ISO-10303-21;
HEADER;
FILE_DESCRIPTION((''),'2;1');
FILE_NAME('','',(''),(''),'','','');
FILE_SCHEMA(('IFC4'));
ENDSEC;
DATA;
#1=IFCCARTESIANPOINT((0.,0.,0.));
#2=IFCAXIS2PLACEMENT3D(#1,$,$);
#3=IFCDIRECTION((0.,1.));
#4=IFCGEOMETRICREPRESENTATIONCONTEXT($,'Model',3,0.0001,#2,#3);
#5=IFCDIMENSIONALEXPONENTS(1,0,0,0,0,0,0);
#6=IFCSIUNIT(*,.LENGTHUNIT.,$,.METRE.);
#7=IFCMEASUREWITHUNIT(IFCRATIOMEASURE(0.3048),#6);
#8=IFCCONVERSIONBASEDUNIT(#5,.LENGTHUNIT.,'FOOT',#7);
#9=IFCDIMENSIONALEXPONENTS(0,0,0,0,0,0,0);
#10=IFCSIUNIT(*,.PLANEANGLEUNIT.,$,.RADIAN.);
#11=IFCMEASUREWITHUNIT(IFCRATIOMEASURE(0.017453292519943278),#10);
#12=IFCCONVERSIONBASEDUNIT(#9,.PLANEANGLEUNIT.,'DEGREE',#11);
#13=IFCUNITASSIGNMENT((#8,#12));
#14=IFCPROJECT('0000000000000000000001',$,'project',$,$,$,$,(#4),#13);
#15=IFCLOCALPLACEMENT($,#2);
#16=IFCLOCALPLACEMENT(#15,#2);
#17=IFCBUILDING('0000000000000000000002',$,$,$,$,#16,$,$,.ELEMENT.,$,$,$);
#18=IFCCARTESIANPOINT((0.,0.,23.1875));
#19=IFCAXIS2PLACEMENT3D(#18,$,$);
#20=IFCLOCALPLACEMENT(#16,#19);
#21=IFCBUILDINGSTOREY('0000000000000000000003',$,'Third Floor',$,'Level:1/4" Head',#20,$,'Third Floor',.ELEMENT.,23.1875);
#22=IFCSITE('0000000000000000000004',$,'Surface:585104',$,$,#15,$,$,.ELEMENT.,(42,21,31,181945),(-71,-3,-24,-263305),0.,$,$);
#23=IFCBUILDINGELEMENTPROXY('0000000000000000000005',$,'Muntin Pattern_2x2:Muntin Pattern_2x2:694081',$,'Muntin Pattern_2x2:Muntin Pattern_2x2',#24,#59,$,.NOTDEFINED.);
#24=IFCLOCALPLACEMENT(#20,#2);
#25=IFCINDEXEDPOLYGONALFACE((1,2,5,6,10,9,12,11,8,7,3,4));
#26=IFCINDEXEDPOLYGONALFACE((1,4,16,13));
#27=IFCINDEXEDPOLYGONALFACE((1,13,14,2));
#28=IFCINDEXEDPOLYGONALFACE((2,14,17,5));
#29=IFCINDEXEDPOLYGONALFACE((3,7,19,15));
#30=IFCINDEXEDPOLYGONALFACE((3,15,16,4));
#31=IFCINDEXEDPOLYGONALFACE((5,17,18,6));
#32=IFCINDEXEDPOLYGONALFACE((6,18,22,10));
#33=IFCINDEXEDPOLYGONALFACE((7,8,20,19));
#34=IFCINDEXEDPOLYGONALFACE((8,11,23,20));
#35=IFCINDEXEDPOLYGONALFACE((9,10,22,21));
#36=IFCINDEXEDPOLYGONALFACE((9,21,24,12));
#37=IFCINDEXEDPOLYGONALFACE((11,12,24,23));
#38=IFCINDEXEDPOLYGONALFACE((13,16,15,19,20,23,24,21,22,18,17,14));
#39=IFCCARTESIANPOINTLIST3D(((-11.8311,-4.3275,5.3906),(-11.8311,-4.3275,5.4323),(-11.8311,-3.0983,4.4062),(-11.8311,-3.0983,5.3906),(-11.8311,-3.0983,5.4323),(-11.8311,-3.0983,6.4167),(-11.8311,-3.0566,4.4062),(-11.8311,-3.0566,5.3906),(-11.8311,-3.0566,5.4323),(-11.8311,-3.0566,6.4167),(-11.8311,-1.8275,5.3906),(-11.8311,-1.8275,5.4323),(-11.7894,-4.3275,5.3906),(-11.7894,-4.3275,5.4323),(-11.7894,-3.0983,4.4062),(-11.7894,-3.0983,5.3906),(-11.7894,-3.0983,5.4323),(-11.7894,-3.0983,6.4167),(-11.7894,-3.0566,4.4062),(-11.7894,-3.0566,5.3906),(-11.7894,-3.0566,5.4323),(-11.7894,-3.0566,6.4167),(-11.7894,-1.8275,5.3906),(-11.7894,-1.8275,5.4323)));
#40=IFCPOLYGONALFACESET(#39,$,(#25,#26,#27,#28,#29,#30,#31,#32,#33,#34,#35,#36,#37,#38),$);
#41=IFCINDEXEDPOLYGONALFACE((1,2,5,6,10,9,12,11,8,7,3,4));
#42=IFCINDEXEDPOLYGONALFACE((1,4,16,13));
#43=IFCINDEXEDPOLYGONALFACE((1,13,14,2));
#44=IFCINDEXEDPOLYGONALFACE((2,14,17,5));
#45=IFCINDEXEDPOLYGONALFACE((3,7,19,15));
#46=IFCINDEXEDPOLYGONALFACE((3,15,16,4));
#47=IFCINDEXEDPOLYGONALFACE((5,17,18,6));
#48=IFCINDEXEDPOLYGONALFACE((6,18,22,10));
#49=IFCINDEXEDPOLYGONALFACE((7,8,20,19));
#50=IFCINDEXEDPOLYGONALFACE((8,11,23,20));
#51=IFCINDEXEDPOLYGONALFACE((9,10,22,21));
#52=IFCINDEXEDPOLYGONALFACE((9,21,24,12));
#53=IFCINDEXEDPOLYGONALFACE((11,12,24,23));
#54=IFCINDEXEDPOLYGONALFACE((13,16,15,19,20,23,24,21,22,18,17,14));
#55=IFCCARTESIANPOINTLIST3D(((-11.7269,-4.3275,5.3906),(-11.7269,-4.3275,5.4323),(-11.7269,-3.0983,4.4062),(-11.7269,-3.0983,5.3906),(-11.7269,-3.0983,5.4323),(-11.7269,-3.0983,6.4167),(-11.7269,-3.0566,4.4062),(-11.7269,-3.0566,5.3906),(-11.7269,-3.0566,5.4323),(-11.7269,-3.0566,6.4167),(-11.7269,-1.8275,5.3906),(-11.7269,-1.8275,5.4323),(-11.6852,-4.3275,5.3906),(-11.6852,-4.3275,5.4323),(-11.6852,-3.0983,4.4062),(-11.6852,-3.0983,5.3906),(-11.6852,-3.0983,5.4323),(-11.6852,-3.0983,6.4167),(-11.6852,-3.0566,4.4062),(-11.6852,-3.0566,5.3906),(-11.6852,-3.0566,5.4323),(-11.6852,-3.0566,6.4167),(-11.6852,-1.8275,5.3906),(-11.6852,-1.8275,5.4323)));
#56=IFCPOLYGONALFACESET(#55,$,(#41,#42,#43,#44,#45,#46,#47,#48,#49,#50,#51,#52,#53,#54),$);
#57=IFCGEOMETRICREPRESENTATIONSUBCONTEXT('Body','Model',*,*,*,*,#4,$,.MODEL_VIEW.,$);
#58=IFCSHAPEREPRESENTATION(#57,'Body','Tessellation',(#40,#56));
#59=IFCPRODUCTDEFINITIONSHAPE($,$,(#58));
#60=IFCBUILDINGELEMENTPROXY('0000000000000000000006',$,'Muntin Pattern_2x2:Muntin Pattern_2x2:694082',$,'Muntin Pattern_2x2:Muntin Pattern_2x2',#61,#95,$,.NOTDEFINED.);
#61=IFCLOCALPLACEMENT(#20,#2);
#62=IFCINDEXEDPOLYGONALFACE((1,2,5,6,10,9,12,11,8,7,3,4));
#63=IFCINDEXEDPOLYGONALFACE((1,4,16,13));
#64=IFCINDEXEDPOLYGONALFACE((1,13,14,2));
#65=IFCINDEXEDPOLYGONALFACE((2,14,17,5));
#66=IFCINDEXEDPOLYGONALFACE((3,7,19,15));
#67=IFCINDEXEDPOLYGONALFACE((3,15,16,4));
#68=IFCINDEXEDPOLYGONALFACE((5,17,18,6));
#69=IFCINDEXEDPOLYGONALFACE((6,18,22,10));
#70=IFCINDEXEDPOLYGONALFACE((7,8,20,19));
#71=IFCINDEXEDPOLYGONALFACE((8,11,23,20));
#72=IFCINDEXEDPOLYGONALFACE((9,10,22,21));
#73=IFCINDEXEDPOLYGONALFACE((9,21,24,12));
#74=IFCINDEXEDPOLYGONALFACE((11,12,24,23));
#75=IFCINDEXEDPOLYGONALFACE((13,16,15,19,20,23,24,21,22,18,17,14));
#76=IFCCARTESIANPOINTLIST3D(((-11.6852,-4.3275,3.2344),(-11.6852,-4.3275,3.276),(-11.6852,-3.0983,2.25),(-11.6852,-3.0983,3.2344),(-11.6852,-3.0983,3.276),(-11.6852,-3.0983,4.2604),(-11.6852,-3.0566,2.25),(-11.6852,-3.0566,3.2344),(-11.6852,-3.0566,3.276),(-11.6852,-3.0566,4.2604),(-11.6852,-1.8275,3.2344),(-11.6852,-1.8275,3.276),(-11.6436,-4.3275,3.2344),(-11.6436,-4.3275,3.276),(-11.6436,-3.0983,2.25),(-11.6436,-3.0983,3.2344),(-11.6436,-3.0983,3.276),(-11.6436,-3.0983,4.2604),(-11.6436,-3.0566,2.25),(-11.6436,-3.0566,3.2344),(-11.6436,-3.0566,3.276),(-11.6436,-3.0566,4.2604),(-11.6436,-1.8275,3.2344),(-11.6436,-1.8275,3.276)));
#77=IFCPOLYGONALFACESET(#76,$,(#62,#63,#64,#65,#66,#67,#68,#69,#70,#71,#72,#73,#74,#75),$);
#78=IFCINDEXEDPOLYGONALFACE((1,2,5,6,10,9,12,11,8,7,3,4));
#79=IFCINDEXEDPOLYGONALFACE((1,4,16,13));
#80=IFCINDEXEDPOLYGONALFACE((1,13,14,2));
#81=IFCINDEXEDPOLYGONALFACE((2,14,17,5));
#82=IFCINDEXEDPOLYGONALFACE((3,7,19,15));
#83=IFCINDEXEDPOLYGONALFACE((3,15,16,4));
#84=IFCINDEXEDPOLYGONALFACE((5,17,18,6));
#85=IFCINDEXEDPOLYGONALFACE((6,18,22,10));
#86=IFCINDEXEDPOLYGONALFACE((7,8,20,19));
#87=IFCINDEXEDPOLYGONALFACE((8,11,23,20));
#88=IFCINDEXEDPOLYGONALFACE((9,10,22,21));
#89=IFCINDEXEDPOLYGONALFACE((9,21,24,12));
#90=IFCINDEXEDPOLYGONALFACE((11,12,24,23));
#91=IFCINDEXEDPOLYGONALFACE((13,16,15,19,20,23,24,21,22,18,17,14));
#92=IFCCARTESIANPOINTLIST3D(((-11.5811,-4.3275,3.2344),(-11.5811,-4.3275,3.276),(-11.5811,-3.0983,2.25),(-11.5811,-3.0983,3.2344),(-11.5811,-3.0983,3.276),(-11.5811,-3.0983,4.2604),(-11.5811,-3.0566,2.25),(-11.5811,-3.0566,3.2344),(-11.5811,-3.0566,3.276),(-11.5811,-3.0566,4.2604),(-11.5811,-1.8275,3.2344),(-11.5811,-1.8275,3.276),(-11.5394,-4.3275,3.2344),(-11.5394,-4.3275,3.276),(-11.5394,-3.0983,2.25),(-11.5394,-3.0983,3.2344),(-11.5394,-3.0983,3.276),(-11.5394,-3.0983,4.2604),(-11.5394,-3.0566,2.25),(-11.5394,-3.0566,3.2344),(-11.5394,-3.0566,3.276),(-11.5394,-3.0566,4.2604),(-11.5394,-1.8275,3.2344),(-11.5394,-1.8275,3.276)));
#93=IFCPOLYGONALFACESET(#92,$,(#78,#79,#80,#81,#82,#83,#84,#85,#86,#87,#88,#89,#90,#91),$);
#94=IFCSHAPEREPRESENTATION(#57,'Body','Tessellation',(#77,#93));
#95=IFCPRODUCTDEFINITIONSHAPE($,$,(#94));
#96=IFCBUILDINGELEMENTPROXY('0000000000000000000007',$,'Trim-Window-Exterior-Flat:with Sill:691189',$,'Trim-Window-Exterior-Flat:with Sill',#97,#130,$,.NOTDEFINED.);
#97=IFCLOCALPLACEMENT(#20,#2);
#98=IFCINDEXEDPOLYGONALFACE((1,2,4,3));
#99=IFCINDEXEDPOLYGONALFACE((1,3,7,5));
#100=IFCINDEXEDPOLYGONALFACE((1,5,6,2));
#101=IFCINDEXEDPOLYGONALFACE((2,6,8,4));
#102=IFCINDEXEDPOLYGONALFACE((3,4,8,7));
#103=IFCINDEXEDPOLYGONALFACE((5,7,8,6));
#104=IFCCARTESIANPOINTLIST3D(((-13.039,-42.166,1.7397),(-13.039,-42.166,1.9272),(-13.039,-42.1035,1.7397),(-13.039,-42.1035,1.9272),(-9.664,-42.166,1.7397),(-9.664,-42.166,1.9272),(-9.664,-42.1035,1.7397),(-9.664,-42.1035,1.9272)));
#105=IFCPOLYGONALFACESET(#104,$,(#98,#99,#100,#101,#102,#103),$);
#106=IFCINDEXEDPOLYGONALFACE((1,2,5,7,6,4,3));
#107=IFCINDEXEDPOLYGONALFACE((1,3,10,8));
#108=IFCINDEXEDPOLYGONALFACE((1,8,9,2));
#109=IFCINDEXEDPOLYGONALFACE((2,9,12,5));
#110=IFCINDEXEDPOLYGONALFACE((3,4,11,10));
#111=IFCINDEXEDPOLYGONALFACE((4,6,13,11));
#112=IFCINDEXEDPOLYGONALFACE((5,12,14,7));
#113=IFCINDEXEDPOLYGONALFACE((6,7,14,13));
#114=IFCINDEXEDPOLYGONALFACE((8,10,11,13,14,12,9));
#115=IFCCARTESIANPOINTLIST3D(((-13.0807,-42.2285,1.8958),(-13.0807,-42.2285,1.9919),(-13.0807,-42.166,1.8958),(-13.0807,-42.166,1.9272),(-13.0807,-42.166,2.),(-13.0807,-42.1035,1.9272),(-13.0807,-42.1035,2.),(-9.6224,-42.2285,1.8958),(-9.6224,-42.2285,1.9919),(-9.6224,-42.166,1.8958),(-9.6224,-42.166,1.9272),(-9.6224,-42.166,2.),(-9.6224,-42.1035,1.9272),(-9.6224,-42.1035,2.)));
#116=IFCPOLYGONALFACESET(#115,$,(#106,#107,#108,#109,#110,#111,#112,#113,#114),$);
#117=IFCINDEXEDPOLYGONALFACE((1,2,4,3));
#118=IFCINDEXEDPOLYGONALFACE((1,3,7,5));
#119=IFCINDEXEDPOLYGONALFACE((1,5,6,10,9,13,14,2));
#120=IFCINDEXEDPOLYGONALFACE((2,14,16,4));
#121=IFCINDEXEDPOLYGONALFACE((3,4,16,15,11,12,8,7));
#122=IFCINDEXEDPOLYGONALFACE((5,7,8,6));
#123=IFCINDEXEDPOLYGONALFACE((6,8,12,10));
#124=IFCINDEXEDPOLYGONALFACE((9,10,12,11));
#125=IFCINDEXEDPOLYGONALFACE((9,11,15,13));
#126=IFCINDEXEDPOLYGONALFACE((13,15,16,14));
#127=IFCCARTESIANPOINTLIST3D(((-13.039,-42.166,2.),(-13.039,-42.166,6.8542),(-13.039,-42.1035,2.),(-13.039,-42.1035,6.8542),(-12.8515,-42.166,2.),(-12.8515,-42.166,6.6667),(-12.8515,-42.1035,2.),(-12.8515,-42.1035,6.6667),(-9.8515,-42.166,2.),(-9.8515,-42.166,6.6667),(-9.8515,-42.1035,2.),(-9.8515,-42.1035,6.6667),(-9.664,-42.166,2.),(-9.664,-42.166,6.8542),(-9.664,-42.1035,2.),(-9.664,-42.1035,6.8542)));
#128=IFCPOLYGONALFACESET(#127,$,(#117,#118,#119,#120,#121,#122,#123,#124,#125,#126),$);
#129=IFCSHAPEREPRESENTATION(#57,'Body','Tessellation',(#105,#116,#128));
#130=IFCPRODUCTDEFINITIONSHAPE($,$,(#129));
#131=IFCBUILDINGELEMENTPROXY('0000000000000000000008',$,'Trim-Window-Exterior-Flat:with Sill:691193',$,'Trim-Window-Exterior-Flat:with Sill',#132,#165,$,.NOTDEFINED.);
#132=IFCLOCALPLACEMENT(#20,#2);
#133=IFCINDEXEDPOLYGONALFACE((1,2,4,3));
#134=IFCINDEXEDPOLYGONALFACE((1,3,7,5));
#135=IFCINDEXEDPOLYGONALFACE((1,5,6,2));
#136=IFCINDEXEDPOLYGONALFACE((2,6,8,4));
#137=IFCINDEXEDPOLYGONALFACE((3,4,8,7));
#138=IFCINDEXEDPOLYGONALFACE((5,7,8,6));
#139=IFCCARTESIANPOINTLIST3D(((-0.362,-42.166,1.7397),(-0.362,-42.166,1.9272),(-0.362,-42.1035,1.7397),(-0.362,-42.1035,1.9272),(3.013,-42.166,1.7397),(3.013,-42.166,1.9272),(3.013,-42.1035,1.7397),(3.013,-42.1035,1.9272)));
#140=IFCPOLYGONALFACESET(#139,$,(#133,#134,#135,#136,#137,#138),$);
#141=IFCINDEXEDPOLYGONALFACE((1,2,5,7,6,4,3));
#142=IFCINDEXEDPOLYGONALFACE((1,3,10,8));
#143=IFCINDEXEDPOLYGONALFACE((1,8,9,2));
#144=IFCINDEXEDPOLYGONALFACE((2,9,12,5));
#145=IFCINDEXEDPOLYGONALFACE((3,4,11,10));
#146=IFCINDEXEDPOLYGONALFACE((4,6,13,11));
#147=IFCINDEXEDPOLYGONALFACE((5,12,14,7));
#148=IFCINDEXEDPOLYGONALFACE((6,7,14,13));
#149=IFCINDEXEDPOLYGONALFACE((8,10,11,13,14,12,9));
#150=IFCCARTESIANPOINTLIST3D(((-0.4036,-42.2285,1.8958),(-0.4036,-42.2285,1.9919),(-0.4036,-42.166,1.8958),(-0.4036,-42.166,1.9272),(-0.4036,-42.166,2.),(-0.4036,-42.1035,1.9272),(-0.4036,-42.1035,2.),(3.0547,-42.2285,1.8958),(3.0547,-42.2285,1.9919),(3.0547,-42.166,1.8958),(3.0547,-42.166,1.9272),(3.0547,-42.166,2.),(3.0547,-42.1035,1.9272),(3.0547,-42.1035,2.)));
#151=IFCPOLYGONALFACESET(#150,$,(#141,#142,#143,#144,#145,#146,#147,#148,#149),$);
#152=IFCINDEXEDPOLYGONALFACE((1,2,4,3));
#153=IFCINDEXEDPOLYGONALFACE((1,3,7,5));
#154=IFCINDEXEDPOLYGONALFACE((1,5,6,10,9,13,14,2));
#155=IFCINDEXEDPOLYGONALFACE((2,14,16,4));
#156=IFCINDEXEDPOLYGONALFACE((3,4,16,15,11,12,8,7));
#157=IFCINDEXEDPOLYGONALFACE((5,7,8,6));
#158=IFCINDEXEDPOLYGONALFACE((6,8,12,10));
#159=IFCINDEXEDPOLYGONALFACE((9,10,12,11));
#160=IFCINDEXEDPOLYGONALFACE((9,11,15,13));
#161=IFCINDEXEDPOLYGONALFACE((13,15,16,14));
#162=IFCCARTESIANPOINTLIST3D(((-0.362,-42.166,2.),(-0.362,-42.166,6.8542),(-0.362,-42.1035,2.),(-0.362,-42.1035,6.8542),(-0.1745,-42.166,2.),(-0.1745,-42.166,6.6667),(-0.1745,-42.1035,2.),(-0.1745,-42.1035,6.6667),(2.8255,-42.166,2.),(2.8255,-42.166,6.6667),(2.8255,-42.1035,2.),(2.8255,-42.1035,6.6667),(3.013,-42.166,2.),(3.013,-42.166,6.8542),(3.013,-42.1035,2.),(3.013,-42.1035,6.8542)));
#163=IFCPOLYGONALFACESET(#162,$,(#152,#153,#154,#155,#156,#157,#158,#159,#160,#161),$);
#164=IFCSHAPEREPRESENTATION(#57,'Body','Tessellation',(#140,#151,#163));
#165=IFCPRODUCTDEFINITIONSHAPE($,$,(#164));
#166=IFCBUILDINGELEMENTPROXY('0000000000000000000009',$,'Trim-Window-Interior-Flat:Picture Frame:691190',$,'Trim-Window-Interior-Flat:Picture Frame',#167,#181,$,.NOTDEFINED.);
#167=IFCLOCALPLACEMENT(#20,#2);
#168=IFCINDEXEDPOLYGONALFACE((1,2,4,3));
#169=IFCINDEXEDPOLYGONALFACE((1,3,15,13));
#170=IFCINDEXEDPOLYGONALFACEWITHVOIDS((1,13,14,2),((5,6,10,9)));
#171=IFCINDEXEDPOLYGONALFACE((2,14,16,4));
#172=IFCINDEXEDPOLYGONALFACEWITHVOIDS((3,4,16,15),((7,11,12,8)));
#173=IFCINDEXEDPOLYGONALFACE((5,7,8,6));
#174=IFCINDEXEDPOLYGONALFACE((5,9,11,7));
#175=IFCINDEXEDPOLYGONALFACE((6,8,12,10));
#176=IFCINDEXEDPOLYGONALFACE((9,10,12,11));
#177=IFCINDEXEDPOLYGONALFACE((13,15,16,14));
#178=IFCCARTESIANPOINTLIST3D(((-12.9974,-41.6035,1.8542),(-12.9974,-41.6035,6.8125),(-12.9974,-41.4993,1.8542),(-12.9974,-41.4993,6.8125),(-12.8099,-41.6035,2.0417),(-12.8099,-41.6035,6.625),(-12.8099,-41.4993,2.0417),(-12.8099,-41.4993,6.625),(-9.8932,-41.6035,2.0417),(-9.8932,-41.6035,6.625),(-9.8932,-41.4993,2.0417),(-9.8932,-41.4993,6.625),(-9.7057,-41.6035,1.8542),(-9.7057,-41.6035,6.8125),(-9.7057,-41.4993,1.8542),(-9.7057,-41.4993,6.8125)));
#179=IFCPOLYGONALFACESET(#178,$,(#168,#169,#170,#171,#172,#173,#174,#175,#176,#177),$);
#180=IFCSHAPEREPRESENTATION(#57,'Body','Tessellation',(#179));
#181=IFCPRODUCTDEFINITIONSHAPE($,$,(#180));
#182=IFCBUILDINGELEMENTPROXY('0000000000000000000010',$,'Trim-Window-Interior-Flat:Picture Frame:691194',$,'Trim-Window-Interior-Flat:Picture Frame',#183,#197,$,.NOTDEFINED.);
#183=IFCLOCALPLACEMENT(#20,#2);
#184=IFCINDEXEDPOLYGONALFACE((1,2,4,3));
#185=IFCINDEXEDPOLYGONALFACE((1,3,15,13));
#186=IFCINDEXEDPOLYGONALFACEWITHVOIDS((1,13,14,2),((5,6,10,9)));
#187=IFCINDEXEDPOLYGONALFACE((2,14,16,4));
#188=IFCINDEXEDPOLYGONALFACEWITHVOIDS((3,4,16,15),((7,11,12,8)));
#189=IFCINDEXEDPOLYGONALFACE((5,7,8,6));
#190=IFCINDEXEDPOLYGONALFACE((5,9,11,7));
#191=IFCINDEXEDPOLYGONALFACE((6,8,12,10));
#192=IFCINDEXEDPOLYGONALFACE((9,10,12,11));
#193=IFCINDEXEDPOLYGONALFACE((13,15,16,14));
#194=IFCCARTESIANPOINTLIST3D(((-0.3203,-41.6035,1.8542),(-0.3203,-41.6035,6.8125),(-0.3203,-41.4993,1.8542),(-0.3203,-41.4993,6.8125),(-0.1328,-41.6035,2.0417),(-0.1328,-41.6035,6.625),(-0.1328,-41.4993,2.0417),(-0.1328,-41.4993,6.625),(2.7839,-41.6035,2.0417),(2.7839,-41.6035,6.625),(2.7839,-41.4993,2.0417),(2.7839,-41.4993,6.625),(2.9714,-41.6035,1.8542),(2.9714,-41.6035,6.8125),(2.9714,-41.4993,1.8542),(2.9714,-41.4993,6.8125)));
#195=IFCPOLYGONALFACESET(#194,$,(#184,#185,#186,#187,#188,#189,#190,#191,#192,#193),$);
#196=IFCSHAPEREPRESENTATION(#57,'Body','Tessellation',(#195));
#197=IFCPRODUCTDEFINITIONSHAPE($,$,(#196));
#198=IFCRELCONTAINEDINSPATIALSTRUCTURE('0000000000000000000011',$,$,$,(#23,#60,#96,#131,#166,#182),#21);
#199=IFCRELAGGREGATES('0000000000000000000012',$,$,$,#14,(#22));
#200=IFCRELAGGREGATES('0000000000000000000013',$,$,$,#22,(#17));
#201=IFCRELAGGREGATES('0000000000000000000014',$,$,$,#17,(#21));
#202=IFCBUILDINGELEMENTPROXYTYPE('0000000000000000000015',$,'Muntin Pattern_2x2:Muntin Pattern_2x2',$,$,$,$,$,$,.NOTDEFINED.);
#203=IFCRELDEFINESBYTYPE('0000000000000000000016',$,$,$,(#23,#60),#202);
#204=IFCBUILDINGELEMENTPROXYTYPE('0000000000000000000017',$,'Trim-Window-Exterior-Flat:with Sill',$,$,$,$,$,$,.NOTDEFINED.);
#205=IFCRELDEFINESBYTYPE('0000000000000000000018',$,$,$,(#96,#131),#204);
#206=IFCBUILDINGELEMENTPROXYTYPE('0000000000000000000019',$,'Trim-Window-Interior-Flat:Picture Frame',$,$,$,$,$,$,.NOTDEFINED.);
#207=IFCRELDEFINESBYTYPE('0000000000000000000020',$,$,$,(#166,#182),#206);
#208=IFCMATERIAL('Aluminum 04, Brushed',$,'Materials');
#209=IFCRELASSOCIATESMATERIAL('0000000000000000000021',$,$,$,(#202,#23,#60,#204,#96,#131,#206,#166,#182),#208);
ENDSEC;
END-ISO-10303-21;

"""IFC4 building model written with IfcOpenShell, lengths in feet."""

from ifc_helpers import new_model, entity, si_unit, converted_unit, direction, frame, origin, place, context, subcontext, project, spatial, indexed_curve, outline, extrude, source, transform, mapped, material, type_object, type_shapes, element, save


model = new_model("IFC4")

# Units and contexts
model_context = context("Model", 3, precision=0.0001, world=origin(), true_north=direction((0.0, 1.0)))
body_context = subcontext(model_context, "Body", "Model", "MODEL_VIEW")
ifc_project = project(units=[converted_unit("LENGTHUNIT", "FOOT", entity("IfcRatioMeasure", 0.3048), si_unit("LENGTHUNIT", "METRE"), dimensions=[1, 0, 0, 0, 0, 0, 0]), converted_unit("PLANEANGLEUNIT", "DEGREE", entity("IfcRatioMeasure", 0.017453292519943278), si_unit("PLANEANGLEUNIT", "RADIAN"), dimensions=[0, 0, 0, 0, 0, 0, 0])], contexts=[model_context])

# Site, building, storey
site_placement = place(None, origin())
site = spatial("IfcSite", under=ifc_project, at=site_placement, Name="Surface:585104", CompositionType="ELEMENT", RefLatitude=(42, 21, 31, 181945), RefLongitude=(-71, -3, -24, -263305), RefElevation=0.0)
building_placement = place(site_placement, origin())
building = spatial("IfcBuilding", under=site, at=building_placement, CompositionType="ELEMENT")
storey_placement = place(building_placement, frame((0.0, 0.0, 23.1875)))
storey = spatial("IfcBuildingStorey", under=building, at=storey_placement, Name="Third Floor", ObjectType="Level:1/4\" Head", LongName="Third Floor", CompositionType="ELEMENT", Elevation=23.1875)

# Shared definitions
ifc_material_1 = material(Name="Aluminum 04, Brushed", Category="Materials")

# Building element proxies
building_element_proxy_type_1 = type_object("IfcBuildingElementProxyType", Name="Muntin Pattern_2x2:Muntin Pattern_2x2", PredefinedType="NOTDEFINED", material=ifc_material_1)
shared_shape_1 = source(origin(), body_context, "Body", "SweptSolid", [
    extrude(outline(indexed_curve([(0.0208, -0.0208), (1.0052, -0.0208), (1.0052, 0.0208), (0.0208, 0.0208), (0.0208, 1.25), (-0.0208, 1.25), (-0.0208, 0.0208), (-1.0052, 0.0208), (-1.0052, -0.0208), (-0.0208, -0.0208), (-0.0208, -1.25), (0.0208, -1.25), (0.0208, -0.0208)], self_intersect=False)), frame((0.0, 0.0312, 1.0052), z_axis=(0.0, 1.0, 0.0), x_axis=(0.0, 0.0, 1.0)), (0.0, 0.0, 1.0), 0.0417),
    extrude(outline(indexed_curve([(0.0208, -0.0208), (1.0052, -0.0208), (1.0052, 0.0208), (0.0208, 0.0208), (0.0208, 1.25), (-0.0208, 1.25), (-0.0208, 0.0208), (-1.0052, 0.0208), (-1.0052, -0.0208), (-0.0208, -0.0208), (-0.0208, -1.25), (0.0208, -1.25), (0.0208, -0.0208)], self_intersect=False)), frame((0.0, -0.0729, 1.0052), z_axis=(0.0, 1.0, 0.0), x_axis=(0.0, 0.0, 1.0)), (0.0, 0.0, 1.0), 0.0417),
])
type_shapes(building_element_proxy_type_1, [shared_shape_1])
for number, where, z_axis, x_axis, name in (
    (1, (-11.7582, -3.0775, 4.4062), (0.0, 0.0, 1.0), (0.0, 1.0, 0.0), "Muntin Pattern_2x2:Muntin Pattern_2x2:694081"),
    (2, (-11.6123, -3.0775, 2.25), (0.0, 0.0, 1.0), (0.0, 1.0, 0.0), "Muntin Pattern_2x2:Muntin Pattern_2x2:694082"),
):
    element("IfcBuildingElementProxy", number, at=place(storey_placement, frame(where, z_axis=z_axis, x_axis=x_axis)), inside=storey, type_object=building_element_proxy_type_1, material=ifc_material_1, Name=name, ObjectType="Muntin Pattern_2x2:Muntin Pattern_2x2", PredefinedType="NOTDEFINED", context=body_context, shape_type="MappedRepresentation", body=[
        mapped(shared_shape_1, transform((0.0, 0.0, 0.0), scale=1.0)),
    ])
building_element_proxy_type_2 = type_object("IfcBuildingElementProxyType", Name="Trim-Window-Exterior-Flat:with Sill", PredefinedType="NOTDEFINED", material=ifc_material_1)
shared_shape_2 = source(origin(), body_context, "Body", "SweptSolid", [
    extrude(outline(indexed_curve([(-1.6875, -0.0938), (1.6875, -0.0938), (1.6875, 0.0938), (-1.6875, 0.0938), (-1.6875, -0.0938)], self_intersect=False)), frame((0.0, -4.8332, 0.0), z_axis=(0.0, 0.0, 1.0), x_axis=(-1.0, 0.0, 0.0)), (0.0, 0.0, 1.0), 0.0625),
    extrude(outline(indexed_curve([(-0.0625, -0.0525), (0.0, -0.0525), (0.0, -0.0211), (0.0625, -0.0211), (0.0625, 0.0517), (0.0, 0.0517), (-0.0625, 0.0436), (-0.0625, -0.0525)], self_intersect=False)), frame((-1.7292, -4.7184, 0.0625), z_axis=(1.0, 0.0, 0.0), x_axis=(0.0, 0.0, -1.0)), (0.0, 0.0, 1.0), 3.4583),
    extrude(outline(indexed_curve([(-2.474, -1.6875), (2.3802, -1.6875), (2.3802, -1.5), (-2.2865, -1.5), (-2.2865, 1.5), (2.3802, 1.5), (2.3802, 1.6875), (-2.474, 1.6875), (-2.474, -1.6875)], self_intersect=False)), frame((0.0, -2.2865, 0.0), z_axis=(0.0, 0.0, 1.0), x_axis=(0.0, -1.0, 0.0)), (0.0, 0.0, 1.0), 0.0625),
])
type_shapes(building_element_proxy_type_2, [shared_shape_2])
for number, where, z_axis, x_axis, name in (
    (3, (-11.3515, -42.1035, 6.6667), (0.0, -1.0, 0.0), (1.0, 0.0, 0.0), "Trim-Window-Exterior-Flat:with Sill:691189"),
    (4, (1.3255, -42.1035, 6.6667), (0.0, -1.0, 0.0), (1.0, 0.0, 0.0), "Trim-Window-Exterior-Flat:with Sill:691193"),
):
    element("IfcBuildingElementProxy", number, at=place(storey_placement, frame(where, z_axis=z_axis, x_axis=x_axis)), inside=storey, type_object=building_element_proxy_type_2, material=ifc_material_1, Name=name, ObjectType="Trim-Window-Exterior-Flat:with Sill", PredefinedType="NOTDEFINED", context=body_context, shape_type="MappedRepresentation", body=[
        mapped(shared_shape_2, transform((0.0, 0.0, 0.0), scale=1.0)),
    ])
building_element_proxy_type_3 = type_object("IfcBuildingElementProxyType", Name="Trim-Window-Interior-Flat:Picture Frame", PredefinedType="NOTDEFINED", material=ifc_material_1)
shared_shape_3 = source(origin(), body_context, "Body", "SweptSolid", [
    extrude(outline(indexed_curve([(-1.6458, -2.4792), (1.6458, -2.4792), (1.6458, 2.4792), (-1.6458, 2.4792), (-1.6458, -2.4792)], self_intersect=False), holes=[indexed_curve([(-1.4583, -2.2917), (-1.4583, 2.2917), (1.4583, 2.2917), (1.4583, -2.2917), (-1.4583, -2.2917)], self_intersect=False)]), frame((0.0, -2.3333, 0.0), z_axis=(0.0, 0.0, 1.0), x_axis=(-1.0, 0.0, 0.0)), (0.0, 0.0, 1.0), 0.1042),
])
type_shapes(building_element_proxy_type_3, [shared_shape_3])
for number, where, z_axis, x_axis, name in (
    (5, (-11.3515, -41.6035, 6.6667), (0.0, 1.0, 0.0), (-1.0, 0.0, 0.0), "Trim-Window-Interior-Flat:Picture Frame:691190"),
    (6, (1.3255, -41.6035, 6.6667), (0.0, 1.0, 0.0), (-1.0, 0.0, 0.0), "Trim-Window-Interior-Flat:Picture Frame:691194"),
):
    element("IfcBuildingElementProxy", number, at=place(storey_placement, frame(where, z_axis=z_axis, x_axis=x_axis)), inside=storey, type_object=building_element_proxy_type_3, material=ifc_material_1, Name=name, ObjectType="Trim-Window-Interior-Flat:Picture Frame", PredefinedType="NOTDEFINED", context=body_context, shape_type="MappedRepresentation", body=[
        mapped(shared_shape_3, transform((0.0, 0.0, 0.0), scale=1.0)),
    ])

save(model, "model.ifc")
